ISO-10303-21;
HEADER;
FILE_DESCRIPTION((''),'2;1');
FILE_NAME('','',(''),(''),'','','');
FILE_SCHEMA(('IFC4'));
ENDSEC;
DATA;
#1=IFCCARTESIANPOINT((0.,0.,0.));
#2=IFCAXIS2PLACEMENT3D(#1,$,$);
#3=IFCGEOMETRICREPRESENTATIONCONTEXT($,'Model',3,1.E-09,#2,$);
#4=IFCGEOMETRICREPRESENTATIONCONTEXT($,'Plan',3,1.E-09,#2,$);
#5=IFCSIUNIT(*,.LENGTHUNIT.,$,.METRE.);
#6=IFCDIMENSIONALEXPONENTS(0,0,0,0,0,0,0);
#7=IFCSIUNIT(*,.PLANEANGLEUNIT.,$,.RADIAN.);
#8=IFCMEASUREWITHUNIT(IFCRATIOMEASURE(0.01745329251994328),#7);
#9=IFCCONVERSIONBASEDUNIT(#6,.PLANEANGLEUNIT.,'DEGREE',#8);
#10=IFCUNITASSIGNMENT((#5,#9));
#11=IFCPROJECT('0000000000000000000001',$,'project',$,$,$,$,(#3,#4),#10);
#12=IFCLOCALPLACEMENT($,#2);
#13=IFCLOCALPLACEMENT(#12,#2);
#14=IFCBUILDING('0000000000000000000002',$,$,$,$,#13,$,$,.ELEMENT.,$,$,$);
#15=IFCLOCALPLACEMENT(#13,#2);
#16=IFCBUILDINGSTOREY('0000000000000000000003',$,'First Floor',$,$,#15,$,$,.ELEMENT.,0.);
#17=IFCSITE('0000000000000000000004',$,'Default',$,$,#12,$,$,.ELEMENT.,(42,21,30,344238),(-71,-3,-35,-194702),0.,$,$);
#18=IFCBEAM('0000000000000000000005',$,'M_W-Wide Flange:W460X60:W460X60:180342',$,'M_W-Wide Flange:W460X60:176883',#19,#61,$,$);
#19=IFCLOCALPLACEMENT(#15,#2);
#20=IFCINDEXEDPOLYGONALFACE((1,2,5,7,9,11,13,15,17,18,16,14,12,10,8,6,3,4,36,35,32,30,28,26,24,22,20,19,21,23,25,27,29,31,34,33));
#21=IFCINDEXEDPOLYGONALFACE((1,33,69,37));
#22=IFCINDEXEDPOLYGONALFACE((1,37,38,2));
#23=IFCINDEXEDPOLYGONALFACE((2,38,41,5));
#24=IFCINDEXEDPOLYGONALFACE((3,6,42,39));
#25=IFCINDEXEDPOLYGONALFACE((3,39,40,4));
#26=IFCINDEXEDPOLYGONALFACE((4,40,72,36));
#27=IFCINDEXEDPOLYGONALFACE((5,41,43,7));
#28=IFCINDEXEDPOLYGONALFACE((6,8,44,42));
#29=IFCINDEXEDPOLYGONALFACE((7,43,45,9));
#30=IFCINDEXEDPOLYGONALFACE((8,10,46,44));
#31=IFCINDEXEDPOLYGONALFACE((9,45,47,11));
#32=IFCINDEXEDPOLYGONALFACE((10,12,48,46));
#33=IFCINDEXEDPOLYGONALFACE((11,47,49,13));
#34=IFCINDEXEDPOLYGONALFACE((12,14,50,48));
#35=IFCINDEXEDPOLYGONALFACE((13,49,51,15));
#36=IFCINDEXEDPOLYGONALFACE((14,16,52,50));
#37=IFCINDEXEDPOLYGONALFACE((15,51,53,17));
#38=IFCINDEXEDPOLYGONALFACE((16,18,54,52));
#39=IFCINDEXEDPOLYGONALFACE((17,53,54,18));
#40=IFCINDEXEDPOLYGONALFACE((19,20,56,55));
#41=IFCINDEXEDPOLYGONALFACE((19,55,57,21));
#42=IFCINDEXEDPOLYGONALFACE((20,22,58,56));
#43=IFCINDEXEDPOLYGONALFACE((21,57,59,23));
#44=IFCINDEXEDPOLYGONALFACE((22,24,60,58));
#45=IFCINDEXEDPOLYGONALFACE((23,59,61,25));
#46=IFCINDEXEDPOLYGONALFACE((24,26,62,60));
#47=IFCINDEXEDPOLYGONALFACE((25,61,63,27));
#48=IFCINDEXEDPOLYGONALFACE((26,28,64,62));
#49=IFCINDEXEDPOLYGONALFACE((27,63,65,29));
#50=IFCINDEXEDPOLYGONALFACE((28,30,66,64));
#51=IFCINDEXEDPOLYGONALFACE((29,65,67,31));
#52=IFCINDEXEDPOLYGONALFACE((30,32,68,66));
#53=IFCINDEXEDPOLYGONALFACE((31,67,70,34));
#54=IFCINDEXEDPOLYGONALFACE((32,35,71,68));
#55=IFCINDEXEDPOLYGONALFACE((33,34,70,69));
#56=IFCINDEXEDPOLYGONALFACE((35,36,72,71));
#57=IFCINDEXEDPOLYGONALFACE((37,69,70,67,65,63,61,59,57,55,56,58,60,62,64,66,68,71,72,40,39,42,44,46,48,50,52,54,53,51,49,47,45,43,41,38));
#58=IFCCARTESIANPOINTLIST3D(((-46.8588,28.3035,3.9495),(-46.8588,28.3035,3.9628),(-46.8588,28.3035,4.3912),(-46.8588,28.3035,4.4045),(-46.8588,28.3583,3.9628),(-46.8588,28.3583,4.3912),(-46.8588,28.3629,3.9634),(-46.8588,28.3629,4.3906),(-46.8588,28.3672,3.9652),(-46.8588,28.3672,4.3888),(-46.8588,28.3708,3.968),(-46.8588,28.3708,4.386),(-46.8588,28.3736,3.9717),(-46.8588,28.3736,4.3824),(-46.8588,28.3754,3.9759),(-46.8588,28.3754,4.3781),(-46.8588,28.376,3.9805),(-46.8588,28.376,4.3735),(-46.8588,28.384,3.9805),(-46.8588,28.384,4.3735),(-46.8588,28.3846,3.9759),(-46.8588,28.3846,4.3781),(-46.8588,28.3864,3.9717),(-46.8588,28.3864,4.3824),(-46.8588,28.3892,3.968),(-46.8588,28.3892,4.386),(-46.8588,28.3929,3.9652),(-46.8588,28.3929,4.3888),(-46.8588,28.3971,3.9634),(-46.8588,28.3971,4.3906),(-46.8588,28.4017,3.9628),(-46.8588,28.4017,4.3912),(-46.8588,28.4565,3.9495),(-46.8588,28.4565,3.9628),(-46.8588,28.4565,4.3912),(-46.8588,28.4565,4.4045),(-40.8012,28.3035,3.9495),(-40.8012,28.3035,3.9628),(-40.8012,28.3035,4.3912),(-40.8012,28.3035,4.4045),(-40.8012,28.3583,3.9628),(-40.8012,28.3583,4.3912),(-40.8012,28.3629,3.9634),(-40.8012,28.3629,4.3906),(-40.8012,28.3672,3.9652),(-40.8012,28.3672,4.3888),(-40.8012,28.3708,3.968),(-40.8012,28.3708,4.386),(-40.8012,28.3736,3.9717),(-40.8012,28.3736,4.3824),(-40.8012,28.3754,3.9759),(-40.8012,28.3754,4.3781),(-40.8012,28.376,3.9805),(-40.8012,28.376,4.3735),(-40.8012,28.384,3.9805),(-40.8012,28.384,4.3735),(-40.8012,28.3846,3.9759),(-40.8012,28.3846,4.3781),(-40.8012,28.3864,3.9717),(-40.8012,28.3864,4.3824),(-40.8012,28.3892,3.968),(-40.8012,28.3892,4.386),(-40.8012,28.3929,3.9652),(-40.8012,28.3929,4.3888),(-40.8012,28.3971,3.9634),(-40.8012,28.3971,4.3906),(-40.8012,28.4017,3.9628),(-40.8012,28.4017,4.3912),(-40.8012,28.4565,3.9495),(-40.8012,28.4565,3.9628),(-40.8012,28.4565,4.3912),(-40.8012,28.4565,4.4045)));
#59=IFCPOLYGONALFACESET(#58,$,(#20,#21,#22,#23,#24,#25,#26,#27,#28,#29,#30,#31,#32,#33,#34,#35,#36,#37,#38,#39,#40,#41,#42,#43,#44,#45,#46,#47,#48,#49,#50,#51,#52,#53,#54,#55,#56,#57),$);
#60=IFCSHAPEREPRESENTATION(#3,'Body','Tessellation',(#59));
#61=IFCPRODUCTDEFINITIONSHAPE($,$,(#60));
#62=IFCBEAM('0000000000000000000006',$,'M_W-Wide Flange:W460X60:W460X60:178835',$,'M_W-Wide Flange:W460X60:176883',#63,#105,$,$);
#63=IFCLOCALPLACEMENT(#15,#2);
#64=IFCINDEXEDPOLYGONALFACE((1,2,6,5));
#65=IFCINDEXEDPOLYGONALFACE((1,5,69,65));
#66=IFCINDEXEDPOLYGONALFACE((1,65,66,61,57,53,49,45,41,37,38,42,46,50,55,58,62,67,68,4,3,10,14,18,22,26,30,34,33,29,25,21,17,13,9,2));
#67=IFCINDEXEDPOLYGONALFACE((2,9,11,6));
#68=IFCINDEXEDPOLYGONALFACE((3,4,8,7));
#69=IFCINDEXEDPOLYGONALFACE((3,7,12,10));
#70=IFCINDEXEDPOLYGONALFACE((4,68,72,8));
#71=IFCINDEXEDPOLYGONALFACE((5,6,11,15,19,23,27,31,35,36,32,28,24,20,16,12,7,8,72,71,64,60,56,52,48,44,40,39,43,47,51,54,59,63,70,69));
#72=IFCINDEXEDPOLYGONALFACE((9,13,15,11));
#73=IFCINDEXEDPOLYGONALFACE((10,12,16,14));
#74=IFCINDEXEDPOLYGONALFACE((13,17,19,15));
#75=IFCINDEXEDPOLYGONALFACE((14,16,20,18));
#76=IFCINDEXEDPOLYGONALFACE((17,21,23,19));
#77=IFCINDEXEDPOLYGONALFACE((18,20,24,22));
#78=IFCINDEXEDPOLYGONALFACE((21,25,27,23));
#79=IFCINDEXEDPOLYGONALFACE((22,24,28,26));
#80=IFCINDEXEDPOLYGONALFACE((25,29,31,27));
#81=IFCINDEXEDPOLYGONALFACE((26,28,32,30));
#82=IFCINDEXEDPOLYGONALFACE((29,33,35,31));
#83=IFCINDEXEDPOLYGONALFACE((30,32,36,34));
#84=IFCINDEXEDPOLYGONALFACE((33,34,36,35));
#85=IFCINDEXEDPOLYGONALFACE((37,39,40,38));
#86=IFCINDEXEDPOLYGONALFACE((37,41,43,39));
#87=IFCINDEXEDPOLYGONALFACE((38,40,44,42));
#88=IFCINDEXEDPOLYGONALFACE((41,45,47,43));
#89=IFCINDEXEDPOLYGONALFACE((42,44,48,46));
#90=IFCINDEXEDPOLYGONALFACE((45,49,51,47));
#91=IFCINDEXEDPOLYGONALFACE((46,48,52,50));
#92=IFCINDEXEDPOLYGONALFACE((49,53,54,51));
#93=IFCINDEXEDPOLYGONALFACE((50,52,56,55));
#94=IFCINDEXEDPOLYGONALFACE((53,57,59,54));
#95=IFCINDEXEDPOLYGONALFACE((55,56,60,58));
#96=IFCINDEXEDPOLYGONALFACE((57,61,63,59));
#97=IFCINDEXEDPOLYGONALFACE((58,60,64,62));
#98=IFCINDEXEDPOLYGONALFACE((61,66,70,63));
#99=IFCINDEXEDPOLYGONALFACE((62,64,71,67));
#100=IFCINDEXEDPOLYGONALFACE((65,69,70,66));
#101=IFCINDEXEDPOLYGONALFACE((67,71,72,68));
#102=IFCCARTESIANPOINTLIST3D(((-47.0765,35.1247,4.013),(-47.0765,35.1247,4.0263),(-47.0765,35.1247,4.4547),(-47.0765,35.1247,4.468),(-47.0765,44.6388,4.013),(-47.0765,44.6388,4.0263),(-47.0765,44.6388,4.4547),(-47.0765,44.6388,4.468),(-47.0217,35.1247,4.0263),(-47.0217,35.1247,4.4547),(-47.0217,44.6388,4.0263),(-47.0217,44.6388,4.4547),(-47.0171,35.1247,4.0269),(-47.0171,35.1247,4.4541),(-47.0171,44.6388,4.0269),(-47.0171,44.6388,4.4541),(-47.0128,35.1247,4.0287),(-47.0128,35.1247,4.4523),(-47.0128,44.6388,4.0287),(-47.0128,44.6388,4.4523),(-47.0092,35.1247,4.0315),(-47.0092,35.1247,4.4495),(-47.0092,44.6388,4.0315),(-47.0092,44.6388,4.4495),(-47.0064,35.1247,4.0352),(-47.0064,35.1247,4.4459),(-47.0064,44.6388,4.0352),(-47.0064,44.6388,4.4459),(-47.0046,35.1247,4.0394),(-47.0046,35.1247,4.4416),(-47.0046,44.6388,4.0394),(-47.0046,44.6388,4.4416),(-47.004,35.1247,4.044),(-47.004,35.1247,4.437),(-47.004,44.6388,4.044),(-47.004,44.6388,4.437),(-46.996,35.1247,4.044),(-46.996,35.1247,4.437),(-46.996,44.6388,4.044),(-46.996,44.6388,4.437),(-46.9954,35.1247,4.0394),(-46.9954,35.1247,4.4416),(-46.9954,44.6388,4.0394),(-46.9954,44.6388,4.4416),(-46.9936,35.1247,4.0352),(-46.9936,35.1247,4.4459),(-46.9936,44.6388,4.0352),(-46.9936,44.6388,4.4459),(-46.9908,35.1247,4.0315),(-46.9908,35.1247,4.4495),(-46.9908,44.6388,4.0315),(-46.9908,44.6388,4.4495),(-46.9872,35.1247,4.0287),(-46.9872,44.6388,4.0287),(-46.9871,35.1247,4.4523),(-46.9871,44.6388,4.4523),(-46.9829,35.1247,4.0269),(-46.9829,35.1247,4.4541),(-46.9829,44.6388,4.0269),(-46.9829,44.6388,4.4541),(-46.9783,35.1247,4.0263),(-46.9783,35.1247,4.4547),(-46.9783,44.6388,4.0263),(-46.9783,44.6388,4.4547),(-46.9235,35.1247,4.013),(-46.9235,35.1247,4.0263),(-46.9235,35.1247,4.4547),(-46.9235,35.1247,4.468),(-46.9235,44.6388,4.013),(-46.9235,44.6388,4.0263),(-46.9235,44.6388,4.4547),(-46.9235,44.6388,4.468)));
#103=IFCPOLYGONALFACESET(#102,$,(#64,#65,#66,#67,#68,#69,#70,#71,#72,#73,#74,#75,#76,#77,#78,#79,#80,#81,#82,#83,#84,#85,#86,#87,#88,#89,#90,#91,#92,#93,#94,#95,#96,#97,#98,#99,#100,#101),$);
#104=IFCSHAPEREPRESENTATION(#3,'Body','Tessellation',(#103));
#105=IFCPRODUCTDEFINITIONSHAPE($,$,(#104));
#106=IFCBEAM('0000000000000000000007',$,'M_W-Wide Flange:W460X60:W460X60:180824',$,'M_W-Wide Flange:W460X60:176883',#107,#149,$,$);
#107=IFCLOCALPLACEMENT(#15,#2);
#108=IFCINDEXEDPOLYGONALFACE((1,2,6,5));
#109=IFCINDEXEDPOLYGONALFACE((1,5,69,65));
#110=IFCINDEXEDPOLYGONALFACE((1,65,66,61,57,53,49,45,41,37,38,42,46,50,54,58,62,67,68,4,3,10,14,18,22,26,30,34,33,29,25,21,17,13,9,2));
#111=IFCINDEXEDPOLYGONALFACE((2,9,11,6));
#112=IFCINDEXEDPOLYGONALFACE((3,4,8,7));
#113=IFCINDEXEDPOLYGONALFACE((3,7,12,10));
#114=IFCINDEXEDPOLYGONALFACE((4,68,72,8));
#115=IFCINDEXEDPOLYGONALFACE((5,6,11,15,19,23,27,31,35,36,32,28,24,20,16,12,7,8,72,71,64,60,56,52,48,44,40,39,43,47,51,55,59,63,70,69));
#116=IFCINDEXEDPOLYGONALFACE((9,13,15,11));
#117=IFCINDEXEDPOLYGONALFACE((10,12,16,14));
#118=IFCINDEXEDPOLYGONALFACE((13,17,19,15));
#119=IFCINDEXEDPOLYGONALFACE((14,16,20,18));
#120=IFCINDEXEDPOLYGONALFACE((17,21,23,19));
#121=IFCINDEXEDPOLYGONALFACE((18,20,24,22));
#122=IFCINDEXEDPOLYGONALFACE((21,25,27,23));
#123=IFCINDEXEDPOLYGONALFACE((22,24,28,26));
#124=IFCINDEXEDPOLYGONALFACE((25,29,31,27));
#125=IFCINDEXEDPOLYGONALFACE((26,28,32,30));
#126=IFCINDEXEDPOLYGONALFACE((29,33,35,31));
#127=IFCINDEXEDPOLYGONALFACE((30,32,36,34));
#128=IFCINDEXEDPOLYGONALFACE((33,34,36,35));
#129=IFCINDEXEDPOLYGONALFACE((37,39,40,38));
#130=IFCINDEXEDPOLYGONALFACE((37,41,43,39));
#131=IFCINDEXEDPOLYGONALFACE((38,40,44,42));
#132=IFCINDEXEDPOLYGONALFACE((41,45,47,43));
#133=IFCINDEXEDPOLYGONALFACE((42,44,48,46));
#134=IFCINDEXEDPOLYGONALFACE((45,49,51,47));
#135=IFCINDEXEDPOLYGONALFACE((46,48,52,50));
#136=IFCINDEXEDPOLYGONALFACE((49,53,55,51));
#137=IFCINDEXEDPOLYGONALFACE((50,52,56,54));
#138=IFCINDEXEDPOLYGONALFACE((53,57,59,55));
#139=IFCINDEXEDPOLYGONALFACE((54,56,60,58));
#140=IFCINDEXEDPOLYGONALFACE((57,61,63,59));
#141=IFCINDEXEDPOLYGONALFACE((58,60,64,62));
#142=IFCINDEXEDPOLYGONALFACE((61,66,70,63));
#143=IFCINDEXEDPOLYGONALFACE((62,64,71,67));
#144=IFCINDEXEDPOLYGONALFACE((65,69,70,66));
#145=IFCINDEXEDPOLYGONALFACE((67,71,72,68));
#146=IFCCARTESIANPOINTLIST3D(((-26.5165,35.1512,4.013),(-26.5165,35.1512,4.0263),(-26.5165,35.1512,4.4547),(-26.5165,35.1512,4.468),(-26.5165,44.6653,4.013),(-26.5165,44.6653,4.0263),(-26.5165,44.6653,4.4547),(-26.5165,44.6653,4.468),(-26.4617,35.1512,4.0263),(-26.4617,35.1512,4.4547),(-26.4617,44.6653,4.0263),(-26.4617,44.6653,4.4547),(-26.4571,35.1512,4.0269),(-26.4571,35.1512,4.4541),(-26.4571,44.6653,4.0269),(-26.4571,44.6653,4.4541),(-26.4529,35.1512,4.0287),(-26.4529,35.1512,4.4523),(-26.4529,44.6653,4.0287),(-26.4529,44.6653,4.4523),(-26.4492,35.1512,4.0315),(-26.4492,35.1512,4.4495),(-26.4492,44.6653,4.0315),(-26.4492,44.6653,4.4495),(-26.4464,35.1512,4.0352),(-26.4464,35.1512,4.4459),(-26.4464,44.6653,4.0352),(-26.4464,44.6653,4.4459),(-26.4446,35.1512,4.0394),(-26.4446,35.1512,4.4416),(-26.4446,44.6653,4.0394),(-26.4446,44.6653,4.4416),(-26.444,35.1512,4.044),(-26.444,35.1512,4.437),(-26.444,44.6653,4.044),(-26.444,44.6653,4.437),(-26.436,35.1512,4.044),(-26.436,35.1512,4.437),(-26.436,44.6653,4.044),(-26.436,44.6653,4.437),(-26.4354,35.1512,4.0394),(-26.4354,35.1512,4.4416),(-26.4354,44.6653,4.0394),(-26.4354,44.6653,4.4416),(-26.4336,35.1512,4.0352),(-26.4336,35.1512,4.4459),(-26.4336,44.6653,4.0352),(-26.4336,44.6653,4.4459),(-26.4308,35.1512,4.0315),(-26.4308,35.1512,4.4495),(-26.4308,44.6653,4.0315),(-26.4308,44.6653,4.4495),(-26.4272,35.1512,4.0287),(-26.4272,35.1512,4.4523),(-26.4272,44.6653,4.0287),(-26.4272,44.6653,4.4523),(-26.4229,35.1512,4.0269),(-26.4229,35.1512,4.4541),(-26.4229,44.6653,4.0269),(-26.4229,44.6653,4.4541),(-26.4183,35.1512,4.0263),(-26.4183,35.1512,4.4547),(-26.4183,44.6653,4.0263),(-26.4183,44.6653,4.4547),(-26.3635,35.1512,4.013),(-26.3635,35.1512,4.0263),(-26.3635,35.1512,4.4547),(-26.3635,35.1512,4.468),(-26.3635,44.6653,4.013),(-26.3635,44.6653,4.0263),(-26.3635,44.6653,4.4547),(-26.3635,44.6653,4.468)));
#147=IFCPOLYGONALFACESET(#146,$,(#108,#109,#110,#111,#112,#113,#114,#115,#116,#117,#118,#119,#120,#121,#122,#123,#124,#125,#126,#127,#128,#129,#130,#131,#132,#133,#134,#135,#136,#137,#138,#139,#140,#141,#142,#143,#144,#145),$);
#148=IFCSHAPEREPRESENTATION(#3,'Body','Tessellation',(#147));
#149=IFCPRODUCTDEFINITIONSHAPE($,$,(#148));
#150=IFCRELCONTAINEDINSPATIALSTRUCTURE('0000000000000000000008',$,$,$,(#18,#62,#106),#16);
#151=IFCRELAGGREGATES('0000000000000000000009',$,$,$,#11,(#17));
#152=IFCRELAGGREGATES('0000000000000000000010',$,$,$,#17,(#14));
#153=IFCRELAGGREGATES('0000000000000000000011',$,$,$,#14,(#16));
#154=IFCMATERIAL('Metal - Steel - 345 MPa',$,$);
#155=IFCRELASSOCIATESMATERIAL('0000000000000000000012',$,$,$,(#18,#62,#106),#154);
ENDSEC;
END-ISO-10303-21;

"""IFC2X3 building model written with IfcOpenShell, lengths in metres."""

from ifc_helpers import new_model, entity, si_unit, converted_unit, frame, frame_2d, origin, place, context, project, spatial, polyline, circle_curve, parameter, trimmed, segment, composite_curve, outline, extrude, material, element, save


model = new_model("IFC2X3")

# Units and contexts
model_context = context("Model", 3, precision=1e-09, world=origin())
plan_context = context("Plan", 3, precision=1e-09, world=origin())
ifc_project = project(units=[si_unit("LENGTHUNIT", "METRE"), converted_unit("PLANEANGLEUNIT", "DEGREE", entity("IfcRatioMeasure", 0.01745329251994328), si_unit("PLANEANGLEUNIT", "RADIAN"), dimensions=[0, 0, 0, 0, 0, 0, 0])], contexts=[model_context, plan_context])

# Site, building, storey
site_placement = place(None, origin())
site = spatial("IfcSite", under=ifc_project, at=site_placement, Name="Default", CompositionType="ELEMENT", RefLatitude=(42, 21, 30, 344238), RefLongitude=(-71, -3, -35, -194702), RefElevation=0.0)
building_placement = place(site_placement, origin())
building = spatial("IfcBuilding", under=site, at=building_placement, CompositionType="ELEMENT")
storey_placement = place(building_placement, origin())
storey = spatial("IfcBuildingStorey", under=building, at=storey_placement, Name="First Floor", CompositionType="ELEMENT", Elevation=0.0)

# Beams
ifc_material = material(Name="Metal - Steel - 345 MPa")
beam_1_placement = place(storey_placement, frame((-40.6578, 28.38, 4.4045), z_axis=(0.0, 0.0, 1.0), x_axis=(0.0, 1.0, 0.0)))
element("IfcBeam", 1, at=beam_1_placement, inside=storey, material=ifc_material, Name="M_W-Wide Flange:W460X60:W460X60:180342", ObjectType="M_W-Wide Flange:W460X60:176883", context=model_context, shape_type="SweptSolid", body=[
    extrude(outline(composite_curve([segment(polyline([(0.2142, -0.0765), (0.2275, -0.0765)]), True, "CONTINUOUS"), segment(polyline([(0.2275, -0.0765), (0.2275, 0.0765)]), True, "CONTINUOUS"), segment(polyline([(0.2275, 0.0765), (0.2142, 0.0765)]), True, "CONTINUOUS"), segment(polyline([(0.2142, 0.0765), (0.2142, 0.0217)]), True, "CONTINUOUS"), segment(trimmed(circle_curve(frame_2d((0.1965, 0.0217), x_axis=(0.0, 1.0)), 0.0177), [parameter(180.0)], [parameter(270.0)], True, "PARAMETER"), False, "CONTINUOUS"), segment(polyline([(0.1965, 0.004), (-0.1965, 0.004)]), True, "CONTINUOUS"), segment(trimmed(circle_curve(frame_2d((-0.1965, 0.0217), x_axis=(0.0, 1.0)), 0.0177), [parameter(90.0)], [parameter(180.0)], True, "PARAMETER"), False, "CONTINUOUS"), segment(polyline([(-0.2142, 0.0217), (-0.2142, 0.0765)]), True, "CONTINUOUS"), segment(polyline([(-0.2142, 0.0765), (-0.2275, 0.0765)]), True, "CONTINUOUS"), segment(polyline([(-0.2275, 0.0765), (-0.2275, -0.0765)]), True, "CONTINUOUS"), segment(polyline([(-0.2275, -0.0765), (-0.2142, -0.0765)]), True, "CONTINUOUS"), segment(polyline([(-0.2142, -0.0765), (-0.2142, -0.0217)]), True, "CONTINUOUS"), segment(trimmed(circle_curve(frame_2d((-0.1965, -0.0217), x_axis=(0.0, 1.0)), 0.0177), [parameter(360.0)], [parameter(90.0)], True, "PARAMETER"), False, "CONTINUOUS"), segment(polyline([(-0.1965, -0.004), (0.1965, -0.004)]), True, "CONTINUOUS"), segment(trimmed(circle_curve(frame_2d((0.1965, -0.0217), x_axis=(0.0, 1.0)), 0.0177), [parameter(270.0)], [parameter(0.0)], True, "PARAMETER"), False, "CONTINUOUS"), segment(polyline([(0.2142, -0.0217), (0.2142, -0.0765)]), True, "CONTINUOUS")], self_intersect=False)), frame((0.0, 6.201, -0.2275), z_axis=(0.0, -1.0, 0.0), x_axis=(0.0, 0.0, -1.0)), (0.0, 0.0, 1.0), 6.0576),
])
beam_2_placement = place(storey_placement, frame((-47.0, 35.0086, 4.468)))
element("IfcBeam", 2, at=beam_2_placement, inside=storey, material=ifc_material, Name="M_W-Wide Flange:W460X60:W460X60:178835", ObjectType="M_W-Wide Flange:W460X60:176883", context=model_context, shape_type="SweptSolid", body=[
    extrude(outline(composite_curve([segment(polyline([(-0.0765, -0.2142), (-0.0765, -0.2275)]), True, "CONTINUOUS"), segment(polyline([(-0.0765, -0.2275), (0.0765, -0.2275)]), True, "CONTINUOUS"), segment(polyline([(0.0765, -0.2275), (0.0765, -0.2142)]), True, "CONTINUOUS"), segment(polyline([(0.0765, -0.2142), (0.0217, -0.2142)]), True, "CONTINUOUS"), segment(trimmed(circle_curve(frame_2d((0.0217, -0.1965), x_axis=(0.0, -1.0)), 0.0177), [parameter(270.0)], [parameter(360.0)], True, "PARAMETER"), False, "CONTINUOUS"), segment(polyline([(0.004, -0.1965), (0.004, 0.1965)]), True, "CONTINUOUS"), segment(trimmed(circle_curve(frame_2d((0.0217, 0.1965), x_axis=(-1.0, 0.0)), 0.0177), [parameter(270.0)], [parameter(360.0)], True, "PARAMETER"), False, "CONTINUOUS"), segment(polyline([(0.0217, 0.2142), (0.0765, 0.2142)]), True, "CONTINUOUS"), segment(polyline([(0.0765, 0.2142), (0.0765, 0.2275)]), True, "CONTINUOUS"), segment(polyline([(0.0765, 0.2275), (-0.0765, 0.2275)]), True, "CONTINUOUS"), segment(polyline([(-0.0765, 0.2275), (-0.0765, 0.2142)]), True, "CONTINUOUS"), segment(polyline([(-0.0765, 0.2142), (-0.0217, 0.2142)]), True, "CONTINUOUS"), segment(trimmed(circle_curve(frame_2d((-0.0217, 0.1965), x_axis=(0.0, 1.0)), 0.0177), [parameter(270.0)], [parameter(360.0)], True, "PARAMETER"), False, "CONTINUOUS"), segment(polyline([(-0.004, 0.1965), (-0.004, -0.1965)]), True, "CONTINUOUS"), segment(trimmed(circle_curve(frame_2d((-0.0217, -0.1965), x_axis=(1.0, 0.0)), 0.0177), [parameter(270.0)], [parameter(0.0)], True, "PARAMETER"), False, "CONTINUOUS"), segment(polyline([(-0.0217, -0.2142), (-0.0765, -0.2142)]), True, "CONTINUOUS")], self_intersect=False)), frame((0.0, 0.1161, -0.2275), z_axis=(0.0, -1.0, 0.0), x_axis=(1.0, 0.0, 0.0)), (0.0, 0.0, -1.0), 9.5141),
])
beam_3_placement = place(storey_placement, frame((-26.44, 44.7814, 4.468), z_axis=(0.0, 0.0, 1.0), x_axis=(-1.0, 0.0, 0.0)))
element("IfcBeam", 3, at=beam_3_placement, inside=storey, material=ifc_material, Name="M_W-Wide Flange:W460X60:W460X60:180824", ObjectType="M_W-Wide Flange:W460X60:176883", context=model_context, shape_type="SweptSolid", body=[
    extrude(outline(composite_curve([segment(polyline([(0.2142, -0.0765), (0.2275, -0.0765)]), True, "CONTINUOUS"), segment(polyline([(0.2275, -0.0765), (0.2275, 0.0765)]), True, "CONTINUOUS"), segment(polyline([(0.2275, 0.0765), (0.2142, 0.0765)]), True, "CONTINUOUS"), segment(polyline([(0.2142, 0.0765), (0.2142, 0.0217)]), True, "CONTINUOUS"), segment(trimmed(circle_curve(frame_2d((0.1965, 0.0217), x_axis=(1.0, 0.0)), 0.0177), [parameter(270.0)], [parameter(360.0)], True, "PARAMETER"), False, "CONTINUOUS"), segment(polyline([(0.1965, 0.004), (-0.1965, 0.004)]), True, "CONTINUOUS"), segment(trimmed(circle_curve(frame_2d((-0.1965, 0.0217), x_axis=(0.0, -1.0)), 0.0177), [parameter(270.0)], [parameter(360.0)], True, "PARAMETER"), False, "CONTINUOUS"), segment(polyline([(-0.2142, 0.0217), (-0.2142, 0.0765)]), True, "CONTINUOUS"), segment(polyline([(-0.2142, 0.0765), (-0.2275, 0.0765)]), True, "CONTINUOUS"), segment(polyline([(-0.2275, 0.0765), (-0.2275, -0.0765)]), True, "CONTINUOUS"), segment(polyline([(-0.2275, -0.0765), (-0.2142, -0.0765)]), True, "CONTINUOUS"), segment(polyline([(-0.2142, -0.0765), (-0.2142, -0.0217)]), True, "CONTINUOUS"), segment(trimmed(circle_curve(frame_2d((-0.1965, -0.0217), x_axis=(-1.0, 0.0)), 0.0177), [parameter(270.0)], [parameter(360.0)], True, "PARAMETER"), False, "CONTINUOUS"), segment(polyline([(-0.1965, -0.004), (0.1965, -0.004)]), True, "CONTINUOUS"), segment(trimmed(circle_curve(frame_2d((0.1965, -0.0217), x_axis=(0.0, 1.0)), 0.0177), [parameter(270.0)], [parameter(0.0)], True, "PARAMETER"), False, "CONTINUOUS"), segment(polyline([(0.2142, -0.0217), (0.2142, -0.0765)]), True, "CONTINUOUS")], self_intersect=False)), frame((0.0, 9.6302, -0.2275), z_axis=(0.0, -1.0, 0.0), x_axis=(0.0, 0.0, -1.0)), (0.0, 0.0, 1.0), 9.5141),
])

save(model, "model.ifc")
